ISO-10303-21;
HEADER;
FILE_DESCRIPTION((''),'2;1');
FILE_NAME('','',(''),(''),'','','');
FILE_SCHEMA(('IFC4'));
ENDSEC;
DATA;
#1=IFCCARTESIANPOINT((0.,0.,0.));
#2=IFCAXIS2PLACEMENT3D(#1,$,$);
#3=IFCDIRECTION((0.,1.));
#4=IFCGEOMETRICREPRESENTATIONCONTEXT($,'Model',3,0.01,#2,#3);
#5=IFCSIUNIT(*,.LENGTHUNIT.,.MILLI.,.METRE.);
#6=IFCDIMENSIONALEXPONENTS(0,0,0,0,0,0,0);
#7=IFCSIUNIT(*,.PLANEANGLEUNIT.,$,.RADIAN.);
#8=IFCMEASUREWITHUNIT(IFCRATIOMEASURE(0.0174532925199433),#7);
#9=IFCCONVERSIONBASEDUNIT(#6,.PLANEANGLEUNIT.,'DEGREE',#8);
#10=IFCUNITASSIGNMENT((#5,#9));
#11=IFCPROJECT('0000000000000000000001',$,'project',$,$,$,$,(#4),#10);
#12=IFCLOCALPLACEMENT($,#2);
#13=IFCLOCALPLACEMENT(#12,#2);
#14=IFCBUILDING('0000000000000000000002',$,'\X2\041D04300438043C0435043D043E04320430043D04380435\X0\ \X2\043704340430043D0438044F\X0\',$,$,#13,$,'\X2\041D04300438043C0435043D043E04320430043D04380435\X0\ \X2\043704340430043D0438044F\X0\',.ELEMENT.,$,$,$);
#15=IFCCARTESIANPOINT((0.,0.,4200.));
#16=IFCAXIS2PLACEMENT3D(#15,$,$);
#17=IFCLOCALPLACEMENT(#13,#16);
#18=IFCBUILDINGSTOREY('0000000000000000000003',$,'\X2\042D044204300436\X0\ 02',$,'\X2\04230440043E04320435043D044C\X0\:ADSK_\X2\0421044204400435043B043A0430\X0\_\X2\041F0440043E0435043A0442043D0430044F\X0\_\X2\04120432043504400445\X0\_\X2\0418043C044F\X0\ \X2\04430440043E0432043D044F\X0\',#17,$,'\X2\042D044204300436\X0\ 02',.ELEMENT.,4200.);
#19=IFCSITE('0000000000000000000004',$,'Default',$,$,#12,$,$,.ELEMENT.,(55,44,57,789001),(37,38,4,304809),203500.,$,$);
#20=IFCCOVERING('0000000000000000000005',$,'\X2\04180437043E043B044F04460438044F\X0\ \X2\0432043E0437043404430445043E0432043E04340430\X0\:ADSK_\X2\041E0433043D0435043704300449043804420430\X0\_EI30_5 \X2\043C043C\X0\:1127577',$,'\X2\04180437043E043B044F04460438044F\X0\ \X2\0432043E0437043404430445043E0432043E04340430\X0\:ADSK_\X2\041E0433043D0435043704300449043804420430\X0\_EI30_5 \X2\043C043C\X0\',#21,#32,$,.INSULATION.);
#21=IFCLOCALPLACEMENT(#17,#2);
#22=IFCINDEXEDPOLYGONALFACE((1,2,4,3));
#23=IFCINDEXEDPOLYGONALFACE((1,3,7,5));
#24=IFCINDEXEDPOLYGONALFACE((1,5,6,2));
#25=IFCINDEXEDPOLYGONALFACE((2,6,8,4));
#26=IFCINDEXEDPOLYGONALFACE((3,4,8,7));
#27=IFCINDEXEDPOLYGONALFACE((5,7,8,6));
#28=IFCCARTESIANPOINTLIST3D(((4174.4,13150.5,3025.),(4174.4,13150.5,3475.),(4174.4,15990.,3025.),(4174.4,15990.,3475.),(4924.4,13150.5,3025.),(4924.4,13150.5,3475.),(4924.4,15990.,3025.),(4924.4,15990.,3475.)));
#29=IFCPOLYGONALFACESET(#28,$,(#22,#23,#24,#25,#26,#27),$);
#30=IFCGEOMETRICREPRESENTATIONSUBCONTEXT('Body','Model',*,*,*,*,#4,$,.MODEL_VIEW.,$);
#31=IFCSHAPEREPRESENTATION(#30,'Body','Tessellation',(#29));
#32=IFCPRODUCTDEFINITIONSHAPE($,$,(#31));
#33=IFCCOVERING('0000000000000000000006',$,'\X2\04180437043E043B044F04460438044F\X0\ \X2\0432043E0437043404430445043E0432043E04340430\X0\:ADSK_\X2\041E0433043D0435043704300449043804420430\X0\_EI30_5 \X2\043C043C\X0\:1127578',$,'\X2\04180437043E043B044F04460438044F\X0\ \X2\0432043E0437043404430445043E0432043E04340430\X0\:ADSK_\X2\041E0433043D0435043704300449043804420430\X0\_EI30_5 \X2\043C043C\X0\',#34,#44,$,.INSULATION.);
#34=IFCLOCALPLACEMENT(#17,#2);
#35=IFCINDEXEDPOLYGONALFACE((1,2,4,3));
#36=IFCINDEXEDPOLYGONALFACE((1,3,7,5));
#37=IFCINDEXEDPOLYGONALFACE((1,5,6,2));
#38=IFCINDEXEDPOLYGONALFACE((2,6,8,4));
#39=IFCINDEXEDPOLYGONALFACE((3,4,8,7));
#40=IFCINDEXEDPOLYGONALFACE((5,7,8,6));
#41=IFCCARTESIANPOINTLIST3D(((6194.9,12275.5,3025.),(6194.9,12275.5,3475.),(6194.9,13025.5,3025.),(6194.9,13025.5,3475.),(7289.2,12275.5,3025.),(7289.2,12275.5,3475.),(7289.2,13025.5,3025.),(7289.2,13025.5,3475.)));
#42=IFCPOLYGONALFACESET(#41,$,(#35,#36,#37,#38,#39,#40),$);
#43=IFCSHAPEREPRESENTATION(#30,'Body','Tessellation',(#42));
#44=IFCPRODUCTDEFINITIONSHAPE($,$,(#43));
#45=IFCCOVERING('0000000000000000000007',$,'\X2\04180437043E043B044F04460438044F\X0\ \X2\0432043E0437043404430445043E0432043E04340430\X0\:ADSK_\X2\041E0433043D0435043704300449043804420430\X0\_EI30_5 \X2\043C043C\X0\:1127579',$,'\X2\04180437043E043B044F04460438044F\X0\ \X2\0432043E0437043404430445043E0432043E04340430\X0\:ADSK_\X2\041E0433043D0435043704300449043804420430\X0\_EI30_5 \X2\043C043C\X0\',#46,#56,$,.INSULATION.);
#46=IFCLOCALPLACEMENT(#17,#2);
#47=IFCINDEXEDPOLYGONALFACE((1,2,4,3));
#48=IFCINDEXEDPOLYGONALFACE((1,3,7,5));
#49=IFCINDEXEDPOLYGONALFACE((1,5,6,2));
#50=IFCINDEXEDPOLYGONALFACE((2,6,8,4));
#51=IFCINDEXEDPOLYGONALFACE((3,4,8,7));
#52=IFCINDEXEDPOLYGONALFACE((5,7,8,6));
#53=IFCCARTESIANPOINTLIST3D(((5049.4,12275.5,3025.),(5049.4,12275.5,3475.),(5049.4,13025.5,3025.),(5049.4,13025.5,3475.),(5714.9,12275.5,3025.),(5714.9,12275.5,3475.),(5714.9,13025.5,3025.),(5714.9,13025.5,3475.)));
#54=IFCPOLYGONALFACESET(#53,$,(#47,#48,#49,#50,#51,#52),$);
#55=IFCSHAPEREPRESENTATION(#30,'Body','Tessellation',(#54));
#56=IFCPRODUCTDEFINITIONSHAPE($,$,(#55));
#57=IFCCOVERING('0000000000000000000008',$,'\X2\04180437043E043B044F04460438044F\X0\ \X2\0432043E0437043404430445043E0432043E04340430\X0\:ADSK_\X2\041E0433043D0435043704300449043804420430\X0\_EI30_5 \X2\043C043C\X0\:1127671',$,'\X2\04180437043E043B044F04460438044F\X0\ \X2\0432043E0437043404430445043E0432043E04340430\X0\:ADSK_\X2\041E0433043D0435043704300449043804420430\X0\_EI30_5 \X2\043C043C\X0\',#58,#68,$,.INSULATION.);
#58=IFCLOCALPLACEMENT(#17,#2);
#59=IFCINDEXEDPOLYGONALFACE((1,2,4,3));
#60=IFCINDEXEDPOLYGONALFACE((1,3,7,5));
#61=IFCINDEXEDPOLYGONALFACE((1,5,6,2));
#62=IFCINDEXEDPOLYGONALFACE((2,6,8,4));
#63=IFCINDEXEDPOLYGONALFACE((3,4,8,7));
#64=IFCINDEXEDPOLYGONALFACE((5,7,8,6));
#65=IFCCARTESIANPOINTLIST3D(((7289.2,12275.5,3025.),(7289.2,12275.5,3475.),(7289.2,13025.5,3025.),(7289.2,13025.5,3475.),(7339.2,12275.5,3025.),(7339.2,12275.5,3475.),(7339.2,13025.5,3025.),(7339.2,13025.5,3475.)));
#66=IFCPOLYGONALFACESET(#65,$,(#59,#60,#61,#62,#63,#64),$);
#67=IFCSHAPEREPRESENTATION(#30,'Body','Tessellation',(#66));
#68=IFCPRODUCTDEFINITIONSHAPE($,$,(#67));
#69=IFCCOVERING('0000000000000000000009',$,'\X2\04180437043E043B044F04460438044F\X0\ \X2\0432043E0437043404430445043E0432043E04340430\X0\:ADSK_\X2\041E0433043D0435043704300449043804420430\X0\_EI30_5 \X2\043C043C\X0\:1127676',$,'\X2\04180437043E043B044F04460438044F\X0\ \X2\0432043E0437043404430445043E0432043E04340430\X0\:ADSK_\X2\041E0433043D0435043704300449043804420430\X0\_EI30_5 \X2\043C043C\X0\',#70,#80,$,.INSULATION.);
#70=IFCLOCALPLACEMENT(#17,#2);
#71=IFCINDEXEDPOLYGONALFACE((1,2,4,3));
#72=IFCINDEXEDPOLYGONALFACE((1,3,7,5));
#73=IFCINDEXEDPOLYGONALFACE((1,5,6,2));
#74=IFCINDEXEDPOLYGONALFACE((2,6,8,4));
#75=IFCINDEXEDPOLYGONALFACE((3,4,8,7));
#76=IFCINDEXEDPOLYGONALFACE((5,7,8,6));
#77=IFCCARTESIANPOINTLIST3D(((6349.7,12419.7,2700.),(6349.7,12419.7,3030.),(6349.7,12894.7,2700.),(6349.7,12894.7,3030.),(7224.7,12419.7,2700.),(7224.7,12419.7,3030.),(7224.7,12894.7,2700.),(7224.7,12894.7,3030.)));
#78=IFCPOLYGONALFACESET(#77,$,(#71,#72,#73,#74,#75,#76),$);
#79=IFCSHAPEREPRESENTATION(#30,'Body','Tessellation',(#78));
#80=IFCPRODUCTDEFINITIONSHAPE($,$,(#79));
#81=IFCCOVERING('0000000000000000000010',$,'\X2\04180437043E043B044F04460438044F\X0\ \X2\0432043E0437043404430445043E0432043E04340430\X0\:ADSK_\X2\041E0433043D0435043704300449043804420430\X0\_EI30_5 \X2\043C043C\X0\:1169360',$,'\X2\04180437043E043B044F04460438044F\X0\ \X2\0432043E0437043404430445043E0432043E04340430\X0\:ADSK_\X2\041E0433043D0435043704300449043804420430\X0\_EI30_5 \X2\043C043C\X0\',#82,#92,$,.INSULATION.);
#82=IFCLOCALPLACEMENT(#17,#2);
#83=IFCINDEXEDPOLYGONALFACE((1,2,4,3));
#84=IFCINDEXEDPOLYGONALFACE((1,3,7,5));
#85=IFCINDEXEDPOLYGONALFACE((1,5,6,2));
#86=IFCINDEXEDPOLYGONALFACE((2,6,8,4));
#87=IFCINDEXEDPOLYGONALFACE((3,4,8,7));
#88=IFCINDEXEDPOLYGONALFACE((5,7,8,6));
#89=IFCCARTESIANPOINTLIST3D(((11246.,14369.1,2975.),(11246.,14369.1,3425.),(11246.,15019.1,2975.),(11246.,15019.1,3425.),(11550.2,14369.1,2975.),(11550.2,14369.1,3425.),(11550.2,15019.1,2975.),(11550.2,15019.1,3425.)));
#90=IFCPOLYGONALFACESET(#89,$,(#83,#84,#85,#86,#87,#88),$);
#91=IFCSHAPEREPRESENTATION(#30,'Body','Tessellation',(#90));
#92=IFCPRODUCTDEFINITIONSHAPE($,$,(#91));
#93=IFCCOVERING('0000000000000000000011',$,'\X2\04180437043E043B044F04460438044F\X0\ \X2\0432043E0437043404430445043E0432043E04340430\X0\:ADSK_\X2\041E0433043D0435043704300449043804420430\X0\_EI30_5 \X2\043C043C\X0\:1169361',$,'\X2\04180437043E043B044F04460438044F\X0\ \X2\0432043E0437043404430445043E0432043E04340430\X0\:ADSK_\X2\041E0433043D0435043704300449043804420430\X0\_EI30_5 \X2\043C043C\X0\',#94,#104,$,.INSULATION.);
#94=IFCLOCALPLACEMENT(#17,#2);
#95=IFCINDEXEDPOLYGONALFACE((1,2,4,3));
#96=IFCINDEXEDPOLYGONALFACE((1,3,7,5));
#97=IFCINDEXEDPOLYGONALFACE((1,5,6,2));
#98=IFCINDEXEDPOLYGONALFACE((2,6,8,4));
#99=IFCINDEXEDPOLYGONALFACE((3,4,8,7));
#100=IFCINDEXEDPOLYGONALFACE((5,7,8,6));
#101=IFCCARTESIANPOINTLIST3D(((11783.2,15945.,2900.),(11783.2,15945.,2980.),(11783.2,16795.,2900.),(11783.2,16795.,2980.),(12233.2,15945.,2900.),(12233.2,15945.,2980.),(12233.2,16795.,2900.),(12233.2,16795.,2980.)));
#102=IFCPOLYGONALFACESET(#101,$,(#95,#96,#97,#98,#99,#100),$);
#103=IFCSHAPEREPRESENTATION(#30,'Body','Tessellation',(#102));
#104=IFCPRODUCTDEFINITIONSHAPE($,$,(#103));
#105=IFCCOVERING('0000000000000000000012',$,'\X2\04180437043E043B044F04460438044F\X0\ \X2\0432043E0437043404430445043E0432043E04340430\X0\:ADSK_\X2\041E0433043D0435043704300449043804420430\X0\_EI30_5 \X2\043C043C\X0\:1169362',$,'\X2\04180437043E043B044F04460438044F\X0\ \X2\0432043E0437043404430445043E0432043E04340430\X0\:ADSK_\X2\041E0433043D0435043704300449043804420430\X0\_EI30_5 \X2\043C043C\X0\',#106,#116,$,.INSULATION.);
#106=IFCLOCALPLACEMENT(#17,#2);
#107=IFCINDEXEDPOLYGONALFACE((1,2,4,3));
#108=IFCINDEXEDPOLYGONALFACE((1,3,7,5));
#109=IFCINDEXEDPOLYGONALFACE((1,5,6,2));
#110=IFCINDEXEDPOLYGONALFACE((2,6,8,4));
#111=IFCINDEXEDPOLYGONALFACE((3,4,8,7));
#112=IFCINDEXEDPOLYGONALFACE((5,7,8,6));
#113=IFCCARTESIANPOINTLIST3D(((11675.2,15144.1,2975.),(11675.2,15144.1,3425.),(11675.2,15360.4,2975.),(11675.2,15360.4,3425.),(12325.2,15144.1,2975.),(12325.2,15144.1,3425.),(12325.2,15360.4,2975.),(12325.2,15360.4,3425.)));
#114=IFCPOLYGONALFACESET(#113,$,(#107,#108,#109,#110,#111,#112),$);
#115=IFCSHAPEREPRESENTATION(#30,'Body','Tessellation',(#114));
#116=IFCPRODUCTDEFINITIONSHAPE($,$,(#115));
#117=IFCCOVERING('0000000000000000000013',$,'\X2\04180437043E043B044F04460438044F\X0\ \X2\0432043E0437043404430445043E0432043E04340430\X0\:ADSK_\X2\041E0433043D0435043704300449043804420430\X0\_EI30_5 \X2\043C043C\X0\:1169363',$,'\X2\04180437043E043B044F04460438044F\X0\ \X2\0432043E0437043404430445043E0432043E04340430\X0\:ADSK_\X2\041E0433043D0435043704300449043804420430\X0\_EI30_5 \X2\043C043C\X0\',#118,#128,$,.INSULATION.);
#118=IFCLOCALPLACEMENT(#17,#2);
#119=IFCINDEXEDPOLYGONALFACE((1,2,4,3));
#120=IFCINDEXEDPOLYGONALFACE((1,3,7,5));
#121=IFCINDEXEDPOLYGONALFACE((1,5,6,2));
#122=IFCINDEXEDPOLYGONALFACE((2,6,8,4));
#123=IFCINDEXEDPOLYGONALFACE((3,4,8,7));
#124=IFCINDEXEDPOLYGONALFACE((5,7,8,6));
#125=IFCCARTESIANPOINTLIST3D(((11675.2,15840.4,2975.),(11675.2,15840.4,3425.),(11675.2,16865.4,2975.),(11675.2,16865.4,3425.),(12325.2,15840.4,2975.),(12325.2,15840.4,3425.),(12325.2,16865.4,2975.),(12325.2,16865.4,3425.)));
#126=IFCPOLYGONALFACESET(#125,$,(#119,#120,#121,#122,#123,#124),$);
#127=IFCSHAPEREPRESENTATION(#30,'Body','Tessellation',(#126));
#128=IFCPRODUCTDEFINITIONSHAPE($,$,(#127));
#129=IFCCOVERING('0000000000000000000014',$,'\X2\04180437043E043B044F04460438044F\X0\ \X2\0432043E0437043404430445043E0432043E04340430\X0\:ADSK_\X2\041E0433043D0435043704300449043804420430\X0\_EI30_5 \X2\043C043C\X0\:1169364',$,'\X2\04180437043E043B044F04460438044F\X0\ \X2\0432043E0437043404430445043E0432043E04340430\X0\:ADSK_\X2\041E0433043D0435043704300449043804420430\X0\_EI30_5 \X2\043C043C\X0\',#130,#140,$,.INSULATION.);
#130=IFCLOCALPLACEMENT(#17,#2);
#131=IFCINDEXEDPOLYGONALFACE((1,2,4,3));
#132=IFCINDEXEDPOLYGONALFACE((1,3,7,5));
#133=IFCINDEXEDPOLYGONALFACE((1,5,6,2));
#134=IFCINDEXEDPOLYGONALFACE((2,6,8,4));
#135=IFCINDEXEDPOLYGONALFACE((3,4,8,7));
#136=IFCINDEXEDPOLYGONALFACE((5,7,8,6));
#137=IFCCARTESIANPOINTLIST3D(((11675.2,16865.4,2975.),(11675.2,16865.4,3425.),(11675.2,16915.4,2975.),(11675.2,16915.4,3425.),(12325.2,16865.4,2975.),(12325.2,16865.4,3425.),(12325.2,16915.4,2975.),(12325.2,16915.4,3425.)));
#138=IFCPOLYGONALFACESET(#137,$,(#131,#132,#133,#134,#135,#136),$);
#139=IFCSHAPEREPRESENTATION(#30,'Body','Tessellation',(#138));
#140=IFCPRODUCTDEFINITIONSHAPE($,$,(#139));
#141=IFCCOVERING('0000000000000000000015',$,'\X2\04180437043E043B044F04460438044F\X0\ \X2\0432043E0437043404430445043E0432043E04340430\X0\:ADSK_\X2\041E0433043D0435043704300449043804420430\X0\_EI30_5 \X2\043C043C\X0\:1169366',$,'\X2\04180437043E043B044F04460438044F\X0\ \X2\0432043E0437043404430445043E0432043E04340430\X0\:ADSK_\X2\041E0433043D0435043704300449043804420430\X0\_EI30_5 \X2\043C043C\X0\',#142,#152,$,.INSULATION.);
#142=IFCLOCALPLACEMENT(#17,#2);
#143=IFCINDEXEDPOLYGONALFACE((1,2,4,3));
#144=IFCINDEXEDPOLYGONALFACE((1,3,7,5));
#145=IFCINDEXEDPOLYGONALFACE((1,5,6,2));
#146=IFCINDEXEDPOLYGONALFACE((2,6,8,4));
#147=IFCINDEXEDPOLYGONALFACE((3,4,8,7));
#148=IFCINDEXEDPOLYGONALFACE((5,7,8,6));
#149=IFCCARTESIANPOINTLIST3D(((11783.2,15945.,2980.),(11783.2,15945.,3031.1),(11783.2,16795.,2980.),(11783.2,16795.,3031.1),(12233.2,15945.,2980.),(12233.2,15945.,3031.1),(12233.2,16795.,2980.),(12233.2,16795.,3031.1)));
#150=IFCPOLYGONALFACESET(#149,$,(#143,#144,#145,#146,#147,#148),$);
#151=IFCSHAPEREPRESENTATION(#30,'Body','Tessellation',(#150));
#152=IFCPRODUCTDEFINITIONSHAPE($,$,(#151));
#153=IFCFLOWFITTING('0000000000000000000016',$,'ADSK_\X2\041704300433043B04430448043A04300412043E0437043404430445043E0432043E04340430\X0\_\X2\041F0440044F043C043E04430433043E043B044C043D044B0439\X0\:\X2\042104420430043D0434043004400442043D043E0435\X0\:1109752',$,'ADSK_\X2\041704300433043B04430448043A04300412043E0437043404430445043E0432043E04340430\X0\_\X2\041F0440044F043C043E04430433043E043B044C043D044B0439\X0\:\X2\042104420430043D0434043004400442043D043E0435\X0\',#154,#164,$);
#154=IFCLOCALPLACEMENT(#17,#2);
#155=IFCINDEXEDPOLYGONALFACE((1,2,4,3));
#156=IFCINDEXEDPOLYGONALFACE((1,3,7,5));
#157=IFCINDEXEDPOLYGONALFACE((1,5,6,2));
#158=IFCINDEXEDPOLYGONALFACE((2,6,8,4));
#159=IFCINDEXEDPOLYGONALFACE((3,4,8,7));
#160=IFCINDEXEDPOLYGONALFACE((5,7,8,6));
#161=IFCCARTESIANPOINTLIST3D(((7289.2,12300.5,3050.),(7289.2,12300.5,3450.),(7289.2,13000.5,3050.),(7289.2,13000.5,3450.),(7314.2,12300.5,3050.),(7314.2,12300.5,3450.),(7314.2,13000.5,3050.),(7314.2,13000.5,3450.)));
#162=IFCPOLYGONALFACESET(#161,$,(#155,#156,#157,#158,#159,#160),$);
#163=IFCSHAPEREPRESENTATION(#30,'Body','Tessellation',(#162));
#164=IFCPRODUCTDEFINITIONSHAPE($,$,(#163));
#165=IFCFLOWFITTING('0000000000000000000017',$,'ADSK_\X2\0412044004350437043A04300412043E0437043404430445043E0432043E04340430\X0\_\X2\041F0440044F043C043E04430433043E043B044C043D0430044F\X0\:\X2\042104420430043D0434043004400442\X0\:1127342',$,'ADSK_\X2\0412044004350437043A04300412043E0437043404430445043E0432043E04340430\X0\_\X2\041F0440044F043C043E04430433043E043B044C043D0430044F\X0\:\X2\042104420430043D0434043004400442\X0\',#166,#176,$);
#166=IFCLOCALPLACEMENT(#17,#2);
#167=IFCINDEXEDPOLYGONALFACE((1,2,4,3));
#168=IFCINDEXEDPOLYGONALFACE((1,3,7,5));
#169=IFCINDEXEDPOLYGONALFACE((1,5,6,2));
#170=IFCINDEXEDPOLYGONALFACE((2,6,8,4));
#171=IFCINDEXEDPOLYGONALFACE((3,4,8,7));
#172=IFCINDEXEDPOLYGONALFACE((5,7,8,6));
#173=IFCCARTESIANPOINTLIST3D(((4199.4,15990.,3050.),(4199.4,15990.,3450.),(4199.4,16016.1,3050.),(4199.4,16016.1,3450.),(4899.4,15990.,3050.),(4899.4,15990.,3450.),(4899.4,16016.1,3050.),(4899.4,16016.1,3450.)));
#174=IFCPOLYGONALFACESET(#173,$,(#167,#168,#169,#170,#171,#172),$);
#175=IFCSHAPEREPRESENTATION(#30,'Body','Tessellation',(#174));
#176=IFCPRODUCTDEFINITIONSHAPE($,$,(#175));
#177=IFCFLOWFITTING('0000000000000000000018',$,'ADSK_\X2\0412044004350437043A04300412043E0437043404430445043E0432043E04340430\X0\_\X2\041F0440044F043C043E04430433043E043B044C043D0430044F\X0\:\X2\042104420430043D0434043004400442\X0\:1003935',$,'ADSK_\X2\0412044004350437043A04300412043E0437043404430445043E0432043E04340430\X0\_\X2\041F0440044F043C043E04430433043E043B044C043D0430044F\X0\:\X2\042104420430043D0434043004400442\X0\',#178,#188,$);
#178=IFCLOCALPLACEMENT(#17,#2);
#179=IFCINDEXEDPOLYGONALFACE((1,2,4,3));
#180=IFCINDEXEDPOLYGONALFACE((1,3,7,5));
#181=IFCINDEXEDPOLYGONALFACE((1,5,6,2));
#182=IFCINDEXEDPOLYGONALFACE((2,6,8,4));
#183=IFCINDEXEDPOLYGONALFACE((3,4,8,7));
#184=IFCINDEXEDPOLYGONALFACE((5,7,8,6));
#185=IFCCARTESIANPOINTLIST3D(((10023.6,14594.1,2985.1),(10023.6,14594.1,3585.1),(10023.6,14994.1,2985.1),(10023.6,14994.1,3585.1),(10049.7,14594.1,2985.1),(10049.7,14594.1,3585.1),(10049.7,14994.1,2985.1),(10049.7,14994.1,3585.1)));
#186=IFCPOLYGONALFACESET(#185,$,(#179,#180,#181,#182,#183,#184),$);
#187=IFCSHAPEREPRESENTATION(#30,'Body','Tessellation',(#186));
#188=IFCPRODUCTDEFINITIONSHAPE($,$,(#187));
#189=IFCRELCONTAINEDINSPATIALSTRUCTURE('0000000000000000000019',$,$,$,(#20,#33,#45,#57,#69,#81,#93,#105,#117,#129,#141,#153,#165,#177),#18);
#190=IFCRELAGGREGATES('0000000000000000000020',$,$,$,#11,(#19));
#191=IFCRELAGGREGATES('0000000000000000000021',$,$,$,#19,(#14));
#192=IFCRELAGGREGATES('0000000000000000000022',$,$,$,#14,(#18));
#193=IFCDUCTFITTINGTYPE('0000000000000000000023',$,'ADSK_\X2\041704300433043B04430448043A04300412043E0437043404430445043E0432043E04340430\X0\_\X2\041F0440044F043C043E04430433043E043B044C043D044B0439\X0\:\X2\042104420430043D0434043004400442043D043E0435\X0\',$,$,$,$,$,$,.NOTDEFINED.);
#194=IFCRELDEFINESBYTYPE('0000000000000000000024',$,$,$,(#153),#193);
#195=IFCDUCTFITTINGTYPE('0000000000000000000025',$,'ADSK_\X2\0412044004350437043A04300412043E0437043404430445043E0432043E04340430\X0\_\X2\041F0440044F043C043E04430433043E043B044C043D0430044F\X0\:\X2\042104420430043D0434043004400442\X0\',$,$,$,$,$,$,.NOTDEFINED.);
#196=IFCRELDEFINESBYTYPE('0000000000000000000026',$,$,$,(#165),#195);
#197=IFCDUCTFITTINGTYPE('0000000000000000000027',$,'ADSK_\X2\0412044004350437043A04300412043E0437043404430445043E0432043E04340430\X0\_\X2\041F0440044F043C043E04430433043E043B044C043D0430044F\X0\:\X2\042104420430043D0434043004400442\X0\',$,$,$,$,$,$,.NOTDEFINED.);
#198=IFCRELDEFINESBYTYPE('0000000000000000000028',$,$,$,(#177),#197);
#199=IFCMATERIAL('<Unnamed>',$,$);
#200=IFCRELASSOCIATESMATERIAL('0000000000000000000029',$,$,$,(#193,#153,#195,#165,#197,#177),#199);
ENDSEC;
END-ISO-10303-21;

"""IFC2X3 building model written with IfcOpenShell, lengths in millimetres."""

from ifc_helpers import new_model, entity, si_unit, converted_unit, direction, frame, origin, origin_2d_with_axis, place, context, subcontext, project, spatial, rectangle, extrude, source, transform, mapped, material, type_object, type_shapes, element, save


model = new_model("IFC2X3")

# Units and contexts
model_context = context("Model", 3, precision=0.01, world=origin(), true_north=direction((0.0, 1.0)))
body_context = subcontext(model_context, "Body", "Model", "MODEL_VIEW")
ifc_project = project(units=[si_unit("LENGTHUNIT", "METRE", prefix="MILLI"), converted_unit("PLANEANGLEUNIT", "DEGREE", entity("IfcRatioMeasure", 0.0174532925199433), si_unit("PLANEANGLEUNIT", "RADIAN"), dimensions=[0, 0, 0, 0, 0, 0, 0])], contexts=[model_context])

# Site, building, storey
site_placement = place(None, origin())
site = spatial("IfcSite", under=ifc_project, at=site_placement, Name="Default", CompositionType="ELEMENT", RefLatitude=(55, 44, 57, 789001), RefLongitude=(37, 38, 4, 304809), RefElevation=203500.0)
building_placement = place(site_placement, origin())
building = spatial("IfcBuilding", under=site, at=building_placement, Name="Наименование здания", LongName="Наименование здания", CompositionType="ELEMENT")
storey_placement = place(building_placement, frame((0.0, 0.0, 4200.0)))
storey = spatial("IfcBuildingStorey", under=building, at=storey_placement, Name="Этаж 02", ObjectType="Уровень:ADSK_Стрелка_Проектная_Вверх_Имя уровня", LongName="Этаж 02", CompositionType="ELEMENT", Elevation=4200.0)

# Coverings
covering_1_placement = place(storey_placement, frame((4174.4, 13150.5, 3025.0)))
element("IfcCovering", 1, at=covering_1_placement, inside=storey, Name="Изоляция воздуховода:ADSK_Огнезащита_EI30_5 мм:1127577", ObjectType="Изоляция воздуховода:ADSK_Огнезащита_EI30_5 мм", PredefinedType="INSULATION", context=body_context, shape_type="SweptSolid", body=[
    extrude(rectangle(XDim=2839.5, YDim=750.0, at=origin_2d_with_axis()), frame((375.0, 1419.8, 0.0), z_axis=(0.0, 0.0, 1.0), x_axis=(0.0, 1.0, 0.0)), (0.0, 0.0, 1.0), 450.0),
])
covering_2_placement = place(storey_placement, frame((6194.9, 12275.5, 3025.0)))
element("IfcCovering", 2, at=covering_2_placement, inside=storey, Name="Изоляция воздуховода:ADSK_Огнезащита_EI30_5 мм:1127578", ObjectType="Изоляция воздуховода:ADSK_Огнезащита_EI30_5 мм", PredefinedType="INSULATION", context=body_context, shape_type="SweptSolid", body=[
    extrude(rectangle(XDim=1094.2, YDim=750.0, at=origin_2d_with_axis()), frame((547.1, 375.0, 0.0), z_axis=(0.0, 0.0, 1.0), x_axis=(-1.0, 0.0, 0.0)), (0.0, 0.0, 1.0), 450.0),
])
covering_3_placement = place(storey_placement, frame((5049.4, 12275.5, 3025.0)))
element("IfcCovering", 3, at=covering_3_placement, inside=storey, Name="Изоляция воздуховода:ADSK_Огнезащита_EI30_5 мм:1127579", ObjectType="Изоляция воздуховода:ADSK_Огнезащита_EI30_5 мм", PredefinedType="INSULATION", context=body_context, shape_type="SweptSolid", body=[
    extrude(rectangle(XDim=665.5, YDim=750.0, at=origin_2d_with_axis()), frame((332.7, 375.0, 0.0), z_axis=(0.0, 0.0, 1.0), x_axis=(-1.0, 0.0, 0.0)), (0.0, 0.0, 1.0), 450.0),
])
covering_4_placement = place(storey_placement, frame((7289.2, 12275.5, 3025.0)))
element("IfcCovering", 4, at=covering_4_placement, inside=storey, Name="Изоляция воздуховода:ADSK_Огнезащита_EI30_5 мм:1127671", ObjectType="Изоляция воздуховода:ADSK_Огнезащита_EI30_5 мм", PredefinedType="INSULATION", context=body_context, shape_type="SweptSolid", body=[
    extrude(rectangle(XDim=50.0, YDim=750.0, at=origin_2d_with_axis()), frame((25.0, 375.0, 0.0), z_axis=(0.0, 0.0, 1.0), x_axis=(-1.0, 0.0, 0.0)), (0.0, 0.0, 1.0), 450.0),
])
covering_5_placement = place(storey_placement, frame((6349.7, 12419.7, 2700.0)))
element("IfcCovering", 5, at=covering_5_placement, inside=storey, Name="Изоляция воздуховода:ADSK_Огнезащита_EI30_5 мм:1127676", ObjectType="Изоляция воздуховода:ADSK_Огнезащита_EI30_5 мм", PredefinedType="INSULATION", context=body_context, shape_type="SweptSolid", body=[
    extrude(rectangle(XDim=875.0, YDim=475.0, at=origin_2d_with_axis()), frame((437.5, 237.5, 0.0)), (0.0, 0.0, 1.0), 330.0),
])
covering_6_placement = place(storey_placement, frame((11246.0, 14369.1, 2975.0)))
element("IfcCovering", 6, at=covering_6_placement, inside=storey, Name="Изоляция воздуховода:ADSK_Огнезащита_EI30_5 мм:1169360", ObjectType="Изоляция воздуховода:ADSK_Огнезащита_EI30_5 мм", PredefinedType="INSULATION", context=body_context, shape_type="SweptSolid", body=[
    extrude(rectangle(XDim=304.2, YDim=650.0, at=origin_2d_with_axis()), frame((152.1, 325.0, 0.0), z_axis=(0.0, 0.0, 1.0), x_axis=(-1.0, 0.0, 0.0)), (0.0, 0.0, 1.0), 450.0),
])
covering_7_placement = place(storey_placement, frame((11783.2, 15945.0, 2900.0)))
element("IfcCovering", 7, at=covering_7_placement, inside=storey, Name="Изоляция воздуховода:ADSK_Огнезащита_EI30_5 мм:1169361", ObjectType="Изоляция воздуховода:ADSK_Огнезащита_EI30_5 мм", PredefinedType="INSULATION", context=body_context, shape_type="SweptSolid", body=[
    extrude(rectangle(XDim=850.0, YDim=450.0, at=origin_2d_with_axis()), frame((225.0, 425.0, 0.0), z_axis=(0.0, 0.0, 1.0), x_axis=(0.0, -1.0, 0.0)), (0.0, 0.0, 1.0), 80.0),
])
covering_8_placement = place(storey_placement, frame((11675.2, 15144.1, 2975.0)))
element("IfcCovering", 8, at=covering_8_placement, inside=storey, Name="Изоляция воздуховода:ADSK_Огнезащита_EI30_5 мм:1169362", ObjectType="Изоляция воздуховода:ADSK_Огнезащита_EI30_5 мм", PredefinedType="INSULATION", context=body_context, shape_type="SweptSolid", body=[
    extrude(rectangle(XDim=216.3, YDim=650.0, at=origin_2d_with_axis()), frame((325.0, 108.2, 0.0), z_axis=(0.0, 0.0, 1.0), x_axis=(0.0, -1.0, 0.0)), (0.0, 0.0, 1.0), 450.0),
])
covering_9_placement = place(storey_placement, frame((11675.2, 15840.4, 2975.0)))
element("IfcCovering", 9, at=covering_9_placement, inside=storey, Name="Изоляция воздуховода:ADSK_Огнезащита_EI30_5 мм:1169363", ObjectType="Изоляция воздуховода:ADSK_Огнезащита_EI30_5 мм", PredefinedType="INSULATION", context=body_context, shape_type="SweptSolid", body=[
    extrude(rectangle(XDim=1025.0, YDim=650.0, at=origin_2d_with_axis()), frame((325.0, 512.5, 0.0), z_axis=(0.0, 0.0, 1.0), x_axis=(0.0, 1.0, 0.0)), (0.0, 0.0, 1.0), 450.0),
])
covering_10_placement = place(storey_placement, frame((11675.2, 16865.4, 2975.0)))
element("IfcCovering", 10, at=covering_10_placement, inside=storey, Name="Изоляция воздуховода:ADSK_Огнезащита_EI30_5 мм:1169364", ObjectType="Изоляция воздуховода:ADSK_Огнезащита_EI30_5 мм", PredefinedType="INSULATION", context=body_context, shape_type="SweptSolid", body=[
    extrude(rectangle(XDim=50.0, YDim=650.0, at=origin_2d_with_axis()), frame((325.0, 25.0, 0.0), z_axis=(0.0, 0.0, 1.0), x_axis=(0.0, -1.0, 0.0)), (0.0, 0.0, 1.0), 450.0),
])
covering_11_placement = place(storey_placement, frame((11783.2, 15945.0, 2980.0)))
element("IfcCovering", 11, at=covering_11_placement, inside=storey, Name="Изоляция воздуховода:ADSK_Огнезащита_EI30_5 мм:1169366", ObjectType="Изоляция воздуховода:ADSK_Огнезащита_EI30_5 мм", PredefinedType="INSULATION", context=body_context, shape_type="SweptSolid", body=[
    extrude(rectangle(XDim=850.0, YDim=450.0, at=origin_2d_with_axis()), frame((225.0, 425.0, 0.0), z_axis=(0.0, 0.0, 1.0), x_axis=(0.0, -1.0, 0.0)), (0.0, 0.0, 1.0), 51.1),
])

# Flow fittings
ifc_material_1 = material(Name="<Unnamed>")
duct_fitting_type_1 = type_object("IfcDuctFittingType", Name="ADSK_ЗаглушкаВоздуховода_Прямоугольный:Стандартное", PredefinedType="NOTDEFINED", material=ifc_material_1)
shared_shape_1 = source(origin(), body_context, "Body", "SweptSolid", [
    extrude(rectangle(XDim=25.0, YDim=700.0, at=origin_2d_with_axis()), frame((12.5, 0.0, -200.0)), (0.0, 0.0, 1.0), 400.0),
])
type_shapes(duct_fitting_type_1, [shared_shape_1])
flow_fitting_1_placement = place(storey_placement, frame((7289.2, 12650.5, 3250.0)))
element("IfcFlowFitting", 12, at=flow_fitting_1_placement, inside=storey, type_object=duct_fitting_type_1, material=ifc_material_1, Name="ADSK_ЗаглушкаВоздуховода_Прямоугольный:Стандартное:1109752", ObjectType="ADSK_ЗаглушкаВоздуховода_Прямоугольный:Стандартное", context=body_context, shape_type="MappedRepresentation", body=[
    mapped(shared_shape_1, transform((0.0, 0.0, 0.0), scale=1.0)),
])
duct_fitting_type_2 = type_object("IfcDuctFittingType", Name="ADSK_ВрезкаВоздуховода_Прямоугольная:Стандарт", PredefinedType="NOTDEFINED", material=ifc_material_1)
shared_shape_2 = source(origin(), body_context, "Body", "SweptSolid", [
    extrude(rectangle(XDim=26.1, YDim=400.0, at=origin_2d_with_axis()), frame((7.0, 0.0, -350.0)), (0.0, 0.0, 1.0), 700.0),
])
type_shapes(duct_fitting_type_2, [shared_shape_2])
flow_fitting_2_placement = place(storey_placement, frame((4549.4, 16010.0, 3250.0), z_axis=(-1.0, 0.0, 0.0), x_axis=(0.0, -1.0, 0.0)))
element("IfcFlowFitting", 13, at=flow_fitting_2_placement, inside=storey, type_object=duct_fitting_type_2, material=ifc_material_1, Name="ADSK_ВрезкаВоздуховода_Прямоугольная:Стандарт:1127342", ObjectType="ADSK_ВрезкаВоздуховода_Прямоугольная:Стандарт", context=body_context, shape_type="MappedRepresentation", body=[
    mapped(shared_shape_2, transform((0.0, 0.0, 0.0), scale=1.0)),
])
duct_fitting_type_3 = type_object("IfcDuctFittingType", Name="ADSK_ВрезкаВоздуховода_Прямоугольная:Стандарт", PredefinedType="NOTDEFINED", material=ifc_material_1)
shared_shape_3 = source(origin(), body_context, "Body", "SweptSolid", [
    extrude(rectangle(XDim=26.1, YDim=600.0, at=origin_2d_with_axis()), frame((7.0, 0.0, -200.0)), (0.0, 0.0, 1.0), 400.0),
])
type_shapes(duct_fitting_type_3, [shared_shape_3])
flow_fitting_3_placement = place(storey_placement, frame((10029.7, 14794.1, 3285.1), z_axis=(0.0, -1.0, 0.0), x_axis=(1.0, 0.0, 0.0)))
element("IfcFlowFitting", 14, at=flow_fitting_3_placement, inside=storey, type_object=duct_fitting_type_3, material=ifc_material_1, Name="ADSK_ВрезкаВоздуховода_Прямоугольная:Стандарт:1003935", ObjectType="ADSK_ВрезкаВоздуховода_Прямоугольная:Стандарт", context=body_context, shape_type="MappedRepresentation", body=[
    mapped(shared_shape_3, transform((0.0, 0.0, 0.0), scale=1.0)),
])

save(model, "model.ifc")
